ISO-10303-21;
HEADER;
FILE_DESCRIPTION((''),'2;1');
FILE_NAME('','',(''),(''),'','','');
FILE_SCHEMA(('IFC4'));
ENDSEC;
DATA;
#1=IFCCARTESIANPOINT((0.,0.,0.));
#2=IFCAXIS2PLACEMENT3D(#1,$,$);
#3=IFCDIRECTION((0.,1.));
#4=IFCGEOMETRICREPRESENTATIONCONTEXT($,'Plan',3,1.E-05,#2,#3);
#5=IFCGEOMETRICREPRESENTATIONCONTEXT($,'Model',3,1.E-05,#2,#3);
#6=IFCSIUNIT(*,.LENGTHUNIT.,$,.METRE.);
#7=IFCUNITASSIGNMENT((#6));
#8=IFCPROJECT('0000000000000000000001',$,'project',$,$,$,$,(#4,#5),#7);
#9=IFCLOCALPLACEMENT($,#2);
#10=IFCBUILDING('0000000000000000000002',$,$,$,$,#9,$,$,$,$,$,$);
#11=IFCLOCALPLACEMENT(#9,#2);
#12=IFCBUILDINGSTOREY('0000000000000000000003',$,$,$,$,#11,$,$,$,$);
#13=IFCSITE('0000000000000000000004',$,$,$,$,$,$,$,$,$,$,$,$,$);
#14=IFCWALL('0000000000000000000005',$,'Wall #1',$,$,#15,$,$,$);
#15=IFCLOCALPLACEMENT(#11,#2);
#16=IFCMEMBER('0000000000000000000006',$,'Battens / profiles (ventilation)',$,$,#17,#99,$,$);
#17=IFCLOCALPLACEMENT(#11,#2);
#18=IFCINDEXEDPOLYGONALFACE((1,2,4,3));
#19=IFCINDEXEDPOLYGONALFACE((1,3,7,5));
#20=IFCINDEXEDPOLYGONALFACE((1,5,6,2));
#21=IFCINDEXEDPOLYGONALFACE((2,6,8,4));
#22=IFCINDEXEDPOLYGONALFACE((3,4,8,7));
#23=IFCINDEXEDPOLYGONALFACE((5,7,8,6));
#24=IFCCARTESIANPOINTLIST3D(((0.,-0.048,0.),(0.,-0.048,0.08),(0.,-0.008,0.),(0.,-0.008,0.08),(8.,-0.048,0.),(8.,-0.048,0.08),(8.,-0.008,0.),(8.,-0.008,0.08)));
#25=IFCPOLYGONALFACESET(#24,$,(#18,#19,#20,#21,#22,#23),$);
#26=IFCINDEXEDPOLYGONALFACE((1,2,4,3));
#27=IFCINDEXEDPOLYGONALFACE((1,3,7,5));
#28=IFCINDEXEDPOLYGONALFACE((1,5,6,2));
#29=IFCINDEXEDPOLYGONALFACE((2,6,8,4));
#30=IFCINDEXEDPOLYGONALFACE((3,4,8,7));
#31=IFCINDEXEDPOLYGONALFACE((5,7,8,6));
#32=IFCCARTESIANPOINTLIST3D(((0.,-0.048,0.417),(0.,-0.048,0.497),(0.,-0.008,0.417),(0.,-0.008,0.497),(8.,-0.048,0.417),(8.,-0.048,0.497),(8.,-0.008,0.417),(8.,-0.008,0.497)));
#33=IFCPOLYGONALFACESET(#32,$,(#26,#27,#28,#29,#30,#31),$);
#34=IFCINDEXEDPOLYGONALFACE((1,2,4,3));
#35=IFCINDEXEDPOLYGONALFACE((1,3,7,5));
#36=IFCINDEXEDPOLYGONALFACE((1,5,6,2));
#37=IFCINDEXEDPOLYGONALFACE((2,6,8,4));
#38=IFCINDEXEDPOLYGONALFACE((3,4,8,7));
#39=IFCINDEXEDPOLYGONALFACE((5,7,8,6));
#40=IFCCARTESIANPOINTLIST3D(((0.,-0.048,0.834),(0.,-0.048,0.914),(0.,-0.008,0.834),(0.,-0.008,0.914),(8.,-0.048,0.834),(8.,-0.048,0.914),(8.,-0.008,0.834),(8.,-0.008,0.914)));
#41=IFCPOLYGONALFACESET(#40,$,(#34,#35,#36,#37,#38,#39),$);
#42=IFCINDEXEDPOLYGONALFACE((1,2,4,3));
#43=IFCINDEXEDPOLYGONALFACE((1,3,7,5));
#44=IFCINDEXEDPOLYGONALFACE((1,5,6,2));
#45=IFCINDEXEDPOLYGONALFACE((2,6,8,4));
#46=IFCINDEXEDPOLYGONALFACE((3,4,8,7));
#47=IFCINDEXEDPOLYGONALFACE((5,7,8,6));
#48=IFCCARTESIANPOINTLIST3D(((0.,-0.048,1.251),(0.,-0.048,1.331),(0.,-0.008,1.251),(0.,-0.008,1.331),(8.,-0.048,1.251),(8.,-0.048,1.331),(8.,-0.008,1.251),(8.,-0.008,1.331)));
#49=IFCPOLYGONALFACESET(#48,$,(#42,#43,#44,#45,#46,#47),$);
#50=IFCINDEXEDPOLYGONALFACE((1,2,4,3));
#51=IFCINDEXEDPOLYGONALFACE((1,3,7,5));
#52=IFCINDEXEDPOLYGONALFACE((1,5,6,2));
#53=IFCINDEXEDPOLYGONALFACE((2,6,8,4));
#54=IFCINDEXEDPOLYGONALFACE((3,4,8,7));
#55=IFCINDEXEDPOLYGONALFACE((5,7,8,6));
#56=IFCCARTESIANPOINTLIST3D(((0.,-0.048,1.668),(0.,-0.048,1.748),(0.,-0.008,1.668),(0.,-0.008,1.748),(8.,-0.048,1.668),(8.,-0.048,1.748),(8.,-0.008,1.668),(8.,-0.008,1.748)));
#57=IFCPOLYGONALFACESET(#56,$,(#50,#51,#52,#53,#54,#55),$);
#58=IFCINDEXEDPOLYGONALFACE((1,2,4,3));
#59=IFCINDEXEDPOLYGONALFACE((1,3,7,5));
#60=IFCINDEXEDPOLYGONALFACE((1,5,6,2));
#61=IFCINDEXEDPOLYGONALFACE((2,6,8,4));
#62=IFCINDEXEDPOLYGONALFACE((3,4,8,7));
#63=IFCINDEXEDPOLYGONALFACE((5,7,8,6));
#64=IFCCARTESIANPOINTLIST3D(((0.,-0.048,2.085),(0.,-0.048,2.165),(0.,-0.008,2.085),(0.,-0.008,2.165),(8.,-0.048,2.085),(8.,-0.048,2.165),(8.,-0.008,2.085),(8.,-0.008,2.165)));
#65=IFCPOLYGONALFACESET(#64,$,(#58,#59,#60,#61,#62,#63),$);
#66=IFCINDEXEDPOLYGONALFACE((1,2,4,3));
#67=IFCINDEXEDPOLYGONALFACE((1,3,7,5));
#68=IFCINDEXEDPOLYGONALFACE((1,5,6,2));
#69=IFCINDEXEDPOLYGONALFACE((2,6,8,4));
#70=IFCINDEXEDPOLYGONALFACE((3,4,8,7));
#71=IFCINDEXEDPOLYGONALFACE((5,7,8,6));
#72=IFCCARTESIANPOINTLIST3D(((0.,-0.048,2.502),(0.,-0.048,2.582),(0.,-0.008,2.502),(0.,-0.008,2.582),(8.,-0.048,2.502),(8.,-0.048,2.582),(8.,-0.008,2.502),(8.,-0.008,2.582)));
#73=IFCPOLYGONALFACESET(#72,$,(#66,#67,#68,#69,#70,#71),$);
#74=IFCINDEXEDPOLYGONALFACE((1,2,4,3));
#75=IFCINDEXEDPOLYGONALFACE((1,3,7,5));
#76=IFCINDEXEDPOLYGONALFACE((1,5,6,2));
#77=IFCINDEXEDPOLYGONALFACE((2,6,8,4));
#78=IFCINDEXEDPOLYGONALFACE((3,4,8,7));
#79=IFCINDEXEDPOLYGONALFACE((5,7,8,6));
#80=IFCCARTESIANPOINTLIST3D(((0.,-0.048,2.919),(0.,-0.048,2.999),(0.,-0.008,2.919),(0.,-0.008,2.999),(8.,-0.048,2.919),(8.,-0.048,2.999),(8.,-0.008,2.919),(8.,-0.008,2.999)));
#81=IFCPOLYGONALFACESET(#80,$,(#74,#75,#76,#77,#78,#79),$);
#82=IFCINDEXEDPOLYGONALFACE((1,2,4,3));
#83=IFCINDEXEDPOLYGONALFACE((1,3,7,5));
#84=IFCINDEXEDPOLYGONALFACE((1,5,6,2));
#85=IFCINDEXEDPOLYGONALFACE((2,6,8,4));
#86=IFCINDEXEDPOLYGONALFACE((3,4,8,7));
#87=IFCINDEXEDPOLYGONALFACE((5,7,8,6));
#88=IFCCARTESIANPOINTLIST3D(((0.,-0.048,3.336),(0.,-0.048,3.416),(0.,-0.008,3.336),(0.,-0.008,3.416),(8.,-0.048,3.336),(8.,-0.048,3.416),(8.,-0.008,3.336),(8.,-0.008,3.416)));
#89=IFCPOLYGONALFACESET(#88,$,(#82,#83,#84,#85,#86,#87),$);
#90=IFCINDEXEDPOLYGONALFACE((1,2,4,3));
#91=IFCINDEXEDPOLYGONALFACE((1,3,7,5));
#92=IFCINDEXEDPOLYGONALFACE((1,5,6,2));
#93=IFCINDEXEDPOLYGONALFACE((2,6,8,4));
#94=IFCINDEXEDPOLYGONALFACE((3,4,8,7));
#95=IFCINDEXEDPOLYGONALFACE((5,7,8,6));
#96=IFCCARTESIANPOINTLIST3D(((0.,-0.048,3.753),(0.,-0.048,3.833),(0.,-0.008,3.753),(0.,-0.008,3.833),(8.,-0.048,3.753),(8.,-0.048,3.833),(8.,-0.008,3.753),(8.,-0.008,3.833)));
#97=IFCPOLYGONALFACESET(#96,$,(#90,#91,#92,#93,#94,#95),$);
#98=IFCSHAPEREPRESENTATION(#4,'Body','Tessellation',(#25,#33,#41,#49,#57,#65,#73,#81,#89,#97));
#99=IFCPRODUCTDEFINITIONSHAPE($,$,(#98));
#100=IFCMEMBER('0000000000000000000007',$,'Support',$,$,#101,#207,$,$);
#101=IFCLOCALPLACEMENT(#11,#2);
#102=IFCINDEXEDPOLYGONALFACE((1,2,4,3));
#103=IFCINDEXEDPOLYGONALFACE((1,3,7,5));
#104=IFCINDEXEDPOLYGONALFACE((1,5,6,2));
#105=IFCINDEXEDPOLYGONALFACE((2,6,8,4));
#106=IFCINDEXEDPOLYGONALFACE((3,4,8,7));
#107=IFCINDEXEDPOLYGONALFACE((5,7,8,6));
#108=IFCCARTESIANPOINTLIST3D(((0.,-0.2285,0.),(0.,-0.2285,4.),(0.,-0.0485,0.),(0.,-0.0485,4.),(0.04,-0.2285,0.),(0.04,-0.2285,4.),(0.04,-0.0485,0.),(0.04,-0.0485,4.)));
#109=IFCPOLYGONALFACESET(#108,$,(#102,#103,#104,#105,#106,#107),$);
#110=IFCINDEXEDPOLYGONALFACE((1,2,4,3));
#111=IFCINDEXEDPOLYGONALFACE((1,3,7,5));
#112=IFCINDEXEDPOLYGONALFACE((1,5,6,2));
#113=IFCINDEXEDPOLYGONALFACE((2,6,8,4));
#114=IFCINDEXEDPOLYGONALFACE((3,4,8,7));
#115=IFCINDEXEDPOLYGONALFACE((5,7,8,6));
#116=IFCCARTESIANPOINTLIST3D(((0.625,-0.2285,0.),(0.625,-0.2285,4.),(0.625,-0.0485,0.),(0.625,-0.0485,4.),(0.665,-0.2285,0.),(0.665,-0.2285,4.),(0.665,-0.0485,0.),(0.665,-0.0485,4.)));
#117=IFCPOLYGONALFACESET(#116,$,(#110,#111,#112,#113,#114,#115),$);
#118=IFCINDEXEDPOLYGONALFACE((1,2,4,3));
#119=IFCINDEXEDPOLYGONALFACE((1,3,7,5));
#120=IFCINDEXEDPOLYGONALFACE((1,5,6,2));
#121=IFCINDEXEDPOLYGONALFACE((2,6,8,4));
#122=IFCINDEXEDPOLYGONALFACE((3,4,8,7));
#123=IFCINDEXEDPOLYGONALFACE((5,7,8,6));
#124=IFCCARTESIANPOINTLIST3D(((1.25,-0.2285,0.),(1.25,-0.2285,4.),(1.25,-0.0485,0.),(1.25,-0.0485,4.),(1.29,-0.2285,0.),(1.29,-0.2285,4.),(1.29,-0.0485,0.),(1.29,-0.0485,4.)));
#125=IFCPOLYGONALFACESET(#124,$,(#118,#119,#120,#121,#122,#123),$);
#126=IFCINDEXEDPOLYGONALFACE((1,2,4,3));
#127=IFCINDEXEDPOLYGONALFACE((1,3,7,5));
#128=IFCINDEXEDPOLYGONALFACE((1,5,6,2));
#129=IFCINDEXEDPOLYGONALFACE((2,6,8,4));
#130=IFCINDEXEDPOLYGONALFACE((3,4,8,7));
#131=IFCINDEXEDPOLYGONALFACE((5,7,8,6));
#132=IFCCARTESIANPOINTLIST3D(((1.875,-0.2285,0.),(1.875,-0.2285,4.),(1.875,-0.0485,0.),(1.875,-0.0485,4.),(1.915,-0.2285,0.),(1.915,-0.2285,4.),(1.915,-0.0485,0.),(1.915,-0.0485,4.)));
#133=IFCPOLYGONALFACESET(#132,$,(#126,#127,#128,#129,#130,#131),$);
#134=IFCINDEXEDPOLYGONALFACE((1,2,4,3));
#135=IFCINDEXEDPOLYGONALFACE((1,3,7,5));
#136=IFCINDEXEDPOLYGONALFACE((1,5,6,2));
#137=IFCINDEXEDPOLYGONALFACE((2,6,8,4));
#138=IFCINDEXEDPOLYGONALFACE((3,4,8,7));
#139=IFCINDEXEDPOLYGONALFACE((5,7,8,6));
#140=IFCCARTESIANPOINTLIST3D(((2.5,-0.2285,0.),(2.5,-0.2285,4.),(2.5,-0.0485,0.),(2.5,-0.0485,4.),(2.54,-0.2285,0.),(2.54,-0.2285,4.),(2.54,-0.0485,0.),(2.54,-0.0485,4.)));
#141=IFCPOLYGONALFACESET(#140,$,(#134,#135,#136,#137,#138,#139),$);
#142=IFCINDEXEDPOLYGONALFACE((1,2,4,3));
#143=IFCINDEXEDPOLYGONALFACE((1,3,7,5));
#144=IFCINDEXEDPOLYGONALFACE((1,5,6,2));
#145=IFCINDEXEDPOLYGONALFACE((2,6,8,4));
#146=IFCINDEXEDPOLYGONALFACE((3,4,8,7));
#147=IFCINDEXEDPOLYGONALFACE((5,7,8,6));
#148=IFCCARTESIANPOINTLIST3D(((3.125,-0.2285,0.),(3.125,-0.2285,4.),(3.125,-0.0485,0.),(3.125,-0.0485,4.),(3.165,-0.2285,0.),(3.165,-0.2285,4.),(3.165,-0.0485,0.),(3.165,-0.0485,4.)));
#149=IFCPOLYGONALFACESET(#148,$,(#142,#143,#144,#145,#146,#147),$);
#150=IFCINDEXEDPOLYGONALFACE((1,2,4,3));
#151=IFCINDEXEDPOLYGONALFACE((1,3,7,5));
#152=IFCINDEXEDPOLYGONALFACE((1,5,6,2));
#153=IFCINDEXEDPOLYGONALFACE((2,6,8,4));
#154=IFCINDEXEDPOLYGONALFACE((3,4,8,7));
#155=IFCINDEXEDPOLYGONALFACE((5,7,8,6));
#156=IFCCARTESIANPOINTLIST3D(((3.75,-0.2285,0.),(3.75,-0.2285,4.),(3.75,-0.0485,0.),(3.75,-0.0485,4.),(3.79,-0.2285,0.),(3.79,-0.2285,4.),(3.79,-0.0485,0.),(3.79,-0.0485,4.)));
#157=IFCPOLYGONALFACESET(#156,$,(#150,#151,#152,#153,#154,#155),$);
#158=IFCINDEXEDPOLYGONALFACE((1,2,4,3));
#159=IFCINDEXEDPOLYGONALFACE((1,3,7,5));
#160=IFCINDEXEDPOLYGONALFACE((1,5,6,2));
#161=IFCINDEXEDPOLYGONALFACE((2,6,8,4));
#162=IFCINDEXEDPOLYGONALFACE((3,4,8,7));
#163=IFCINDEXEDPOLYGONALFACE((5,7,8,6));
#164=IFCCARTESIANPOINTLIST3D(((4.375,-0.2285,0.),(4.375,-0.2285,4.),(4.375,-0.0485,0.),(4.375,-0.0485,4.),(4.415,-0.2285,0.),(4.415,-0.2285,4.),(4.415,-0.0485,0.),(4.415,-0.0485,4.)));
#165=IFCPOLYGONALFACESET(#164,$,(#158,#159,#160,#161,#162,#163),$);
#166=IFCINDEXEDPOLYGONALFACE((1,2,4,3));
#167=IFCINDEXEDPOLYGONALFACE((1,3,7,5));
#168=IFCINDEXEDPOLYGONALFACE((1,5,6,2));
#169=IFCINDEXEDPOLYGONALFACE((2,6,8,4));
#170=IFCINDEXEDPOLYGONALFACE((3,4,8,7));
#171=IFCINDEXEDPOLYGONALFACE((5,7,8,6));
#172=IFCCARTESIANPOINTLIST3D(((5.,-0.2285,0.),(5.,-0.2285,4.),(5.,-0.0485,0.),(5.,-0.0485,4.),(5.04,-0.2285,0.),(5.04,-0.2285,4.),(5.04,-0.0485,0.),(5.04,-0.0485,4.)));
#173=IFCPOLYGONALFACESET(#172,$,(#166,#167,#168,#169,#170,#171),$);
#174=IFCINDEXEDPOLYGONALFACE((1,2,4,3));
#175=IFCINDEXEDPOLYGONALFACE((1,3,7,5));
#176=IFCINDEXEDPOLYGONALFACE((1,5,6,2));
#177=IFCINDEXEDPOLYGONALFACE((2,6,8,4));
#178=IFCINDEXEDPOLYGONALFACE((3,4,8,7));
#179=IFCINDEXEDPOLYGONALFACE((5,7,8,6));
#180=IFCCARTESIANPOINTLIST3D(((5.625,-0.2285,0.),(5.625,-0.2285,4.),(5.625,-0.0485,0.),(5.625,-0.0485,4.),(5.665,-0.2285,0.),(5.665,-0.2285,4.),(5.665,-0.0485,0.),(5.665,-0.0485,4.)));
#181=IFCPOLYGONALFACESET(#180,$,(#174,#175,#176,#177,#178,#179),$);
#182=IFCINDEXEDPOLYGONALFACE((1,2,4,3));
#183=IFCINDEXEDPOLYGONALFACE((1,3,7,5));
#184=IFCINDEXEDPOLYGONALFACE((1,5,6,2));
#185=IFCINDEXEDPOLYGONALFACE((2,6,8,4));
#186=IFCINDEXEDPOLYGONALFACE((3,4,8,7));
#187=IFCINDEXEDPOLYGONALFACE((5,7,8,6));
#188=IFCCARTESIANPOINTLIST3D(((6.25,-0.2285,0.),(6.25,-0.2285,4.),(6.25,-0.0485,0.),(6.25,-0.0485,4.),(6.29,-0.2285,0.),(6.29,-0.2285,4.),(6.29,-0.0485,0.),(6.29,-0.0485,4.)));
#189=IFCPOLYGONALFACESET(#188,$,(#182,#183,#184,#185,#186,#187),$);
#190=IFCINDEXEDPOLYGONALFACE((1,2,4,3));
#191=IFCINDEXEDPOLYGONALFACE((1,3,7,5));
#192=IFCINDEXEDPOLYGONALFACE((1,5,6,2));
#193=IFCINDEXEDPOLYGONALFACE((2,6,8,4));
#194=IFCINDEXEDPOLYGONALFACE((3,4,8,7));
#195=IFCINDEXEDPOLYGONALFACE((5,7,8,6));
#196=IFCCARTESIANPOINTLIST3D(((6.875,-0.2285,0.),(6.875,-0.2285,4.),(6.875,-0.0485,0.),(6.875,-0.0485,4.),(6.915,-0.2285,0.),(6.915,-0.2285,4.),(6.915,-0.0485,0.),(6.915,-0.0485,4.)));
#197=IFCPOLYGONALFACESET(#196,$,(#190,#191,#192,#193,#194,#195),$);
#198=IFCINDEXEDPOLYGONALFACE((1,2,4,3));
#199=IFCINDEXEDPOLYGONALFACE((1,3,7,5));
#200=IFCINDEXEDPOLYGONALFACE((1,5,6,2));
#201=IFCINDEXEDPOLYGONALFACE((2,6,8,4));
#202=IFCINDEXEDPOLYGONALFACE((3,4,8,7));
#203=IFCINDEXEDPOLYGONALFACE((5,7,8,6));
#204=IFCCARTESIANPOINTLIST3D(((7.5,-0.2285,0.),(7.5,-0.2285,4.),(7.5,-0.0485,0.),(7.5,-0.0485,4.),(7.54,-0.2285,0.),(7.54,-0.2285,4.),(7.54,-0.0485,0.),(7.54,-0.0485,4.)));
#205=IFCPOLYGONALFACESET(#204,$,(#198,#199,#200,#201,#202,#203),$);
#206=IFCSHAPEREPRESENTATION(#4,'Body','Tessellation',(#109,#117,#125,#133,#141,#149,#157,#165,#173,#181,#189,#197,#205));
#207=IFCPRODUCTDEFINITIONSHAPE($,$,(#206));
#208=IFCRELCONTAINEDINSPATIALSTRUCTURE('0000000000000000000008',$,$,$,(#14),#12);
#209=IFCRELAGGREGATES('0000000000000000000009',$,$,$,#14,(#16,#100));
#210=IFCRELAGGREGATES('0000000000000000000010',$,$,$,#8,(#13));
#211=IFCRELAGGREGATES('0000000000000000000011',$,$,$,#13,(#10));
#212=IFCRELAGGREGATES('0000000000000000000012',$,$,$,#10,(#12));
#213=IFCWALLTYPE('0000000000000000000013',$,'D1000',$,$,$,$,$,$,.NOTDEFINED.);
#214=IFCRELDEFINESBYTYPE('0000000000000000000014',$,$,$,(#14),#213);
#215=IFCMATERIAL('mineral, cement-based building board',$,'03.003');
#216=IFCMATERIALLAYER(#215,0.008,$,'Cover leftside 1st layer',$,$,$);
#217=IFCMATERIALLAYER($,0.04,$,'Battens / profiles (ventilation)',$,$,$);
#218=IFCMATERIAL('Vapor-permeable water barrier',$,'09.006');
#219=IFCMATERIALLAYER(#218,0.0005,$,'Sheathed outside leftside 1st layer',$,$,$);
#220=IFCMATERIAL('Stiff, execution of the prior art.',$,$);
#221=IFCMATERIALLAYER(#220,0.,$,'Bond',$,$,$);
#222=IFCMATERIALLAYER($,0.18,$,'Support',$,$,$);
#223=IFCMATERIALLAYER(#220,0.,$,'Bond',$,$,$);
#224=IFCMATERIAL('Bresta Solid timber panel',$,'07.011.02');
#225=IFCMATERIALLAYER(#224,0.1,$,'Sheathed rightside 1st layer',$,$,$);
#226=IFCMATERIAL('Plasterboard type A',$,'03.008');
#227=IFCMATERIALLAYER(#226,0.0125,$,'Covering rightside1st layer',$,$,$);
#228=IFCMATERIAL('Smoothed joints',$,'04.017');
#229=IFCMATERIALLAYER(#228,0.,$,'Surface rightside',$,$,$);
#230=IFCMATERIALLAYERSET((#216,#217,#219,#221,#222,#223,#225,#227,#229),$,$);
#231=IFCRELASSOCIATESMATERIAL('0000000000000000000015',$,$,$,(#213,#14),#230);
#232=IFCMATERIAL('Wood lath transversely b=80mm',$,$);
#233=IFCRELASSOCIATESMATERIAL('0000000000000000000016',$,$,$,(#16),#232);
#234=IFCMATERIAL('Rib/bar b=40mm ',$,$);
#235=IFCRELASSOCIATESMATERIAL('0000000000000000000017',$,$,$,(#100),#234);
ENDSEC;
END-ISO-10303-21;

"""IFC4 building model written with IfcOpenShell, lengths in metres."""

from ifc_helpers import new_model, si_unit, direction, frame, frame_2d, origin, place, context, project, spatial, rectangle, extrude, material, layer, layer_set, type_object, element, aggregate, save


model = new_model("IFC4")

# Units and contexts
plan_context = context("Plan", 3, precision=1e-05, world=origin(), true_north=direction((0.0, 1.0)))
model_context = context("Model", 3, precision=1e-05, world=origin(), true_north=direction((0.0, 1.0)))
ifc_project = project(units=[si_unit("LENGTHUNIT", "METRE")], contexts=[plan_context, model_context])

# Site, building, storey
site = spatial("IfcSite", under=ifc_project)
building_placement = place(None, origin())
building = spatial("IfcBuilding", under=site, at=building_placement)
storey_placement = place(building_placement, origin())
storey = spatial("IfcBuildingStorey", under=building, at=storey_placement)

# Wall, members
ifc_material_1 = material(Name="mineral, cement-based building board", Category="03.003")
ifc_layer_1 = layer(ifc_material_1, 0.008, Name="Cover leftside 1st layer")
ifc_layer_2 = layer(None, 0.04, Name="Battens / profiles (ventilation)")
ifc_material_2 = material(Name="Vapor-permeable water barrier", Category="09.006")
ifc_layer_3 = layer(ifc_material_2, 0.0005, Name="Sheathed outside leftside 1st layer")
ifc_material_3 = material(Name="Stiff, execution of the prior art.")
ifc_layer_4 = layer(ifc_material_3, 0.0, Name="Bond")
ifc_layer_5 = layer(None, 0.18, Name="Support")
ifc_layer_6 = layer(ifc_material_3, 0.0, Name="Bond")
ifc_material_4 = material(Name="Bresta Solid timber panel", Category="07.011.02")
ifc_layer_7 = layer(ifc_material_4, 0.1, Name="Sheathed rightside 1st layer")
ifc_material_5 = material(Name="Plasterboard type A", Category="03.008")
ifc_layer_8 = layer(ifc_material_5, 0.0125, Name="Covering rightside1st layer")
ifc_material_6 = material(Name="Smoothed joints", Category="04.017")
ifc_layer_9 = layer(ifc_material_6, 0.0, Name="Surface rightside")
ifc_layer_set = layer_set([ifc_layer_1, ifc_layer_2, ifc_layer_3, ifc_layer_4, ifc_layer_5, ifc_layer_6, ifc_layer_7, ifc_layer_8, ifc_layer_9])
wall_type = type_object("IfcWallType", Name="D1000", PredefinedType="NOTDEFINED", material=ifc_layer_set)
wall_placement = place(None, frame((0.0, 0.0, 0.0), z_axis=(0.0, -1.0, 0.0), x_axis=(1.0, 0.0, 0.0)))
wall = element("IfcWall", 1, at=wall_placement, inside=storey, type_object=wall_type, material=ifc_layer_set, Name="Wall #1")
ifc_material_7 = material(Name="Wood lath transversely b=80mm")
member_1_placement = place(wall_placement, origin())
member_1 = element("IfcMember", 2, at=member_1_placement, material=ifc_material_7, Name="Battens / profiles (ventilation)", context=plan_context, shape_type="SweptSolid", body=[
    extrude(rectangle(XDim=0.08, YDim=0.04, at=frame_2d((0.04, 0.02), x_axis=(1.0, 0.0))), frame((0.0, 0.0, 0.008), z_axis=(1.0, 0.0, 0.0), x_axis=(0.0, 1.0, 0.0)), (0.0, 0.0, 1.0), 8.0),
    extrude(rectangle(XDim=0.08, YDim=0.04, at=frame_2d((0.04, 0.02), x_axis=(1.0, 0.0))), frame((0.0, 0.417, 0.008), z_axis=(1.0, 0.0, 0.0), x_axis=(0.0, 1.0, 0.0)), (0.0, 0.0, 1.0), 8.0),
    extrude(rectangle(XDim=0.08, YDim=0.04, at=frame_2d((0.04, 0.02), x_axis=(1.0, 0.0))), frame((0.0, 0.834, 0.008), z_axis=(1.0, 0.0, 0.0), x_axis=(0.0, 1.0, 0.0)), (0.0, 0.0, 1.0), 8.0),
    extrude(rectangle(XDim=0.08, YDim=0.04, at=frame_2d((0.04, 0.02), x_axis=(1.0, 0.0))), frame((0.0, 1.251, 0.008), z_axis=(1.0, 0.0, 0.0), x_axis=(0.0, 1.0, 0.0)), (0.0, 0.0, 1.0), 8.0),
    extrude(rectangle(XDim=0.08, YDim=0.04, at=frame_2d((0.04, 0.02), x_axis=(1.0, 0.0))), frame((0.0, 1.668, 0.008), z_axis=(1.0, 0.0, 0.0), x_axis=(0.0, 1.0, 0.0)), (0.0, 0.0, 1.0), 8.0),
    extrude(rectangle(XDim=0.08, YDim=0.04, at=frame_2d((0.04, 0.02), x_axis=(1.0, 0.0))), frame((0.0, 2.085, 0.008), z_axis=(1.0, 0.0, 0.0), x_axis=(0.0, 1.0, 0.0)), (0.0, 0.0, 1.0), 8.0),
    extrude(rectangle(XDim=0.08, YDim=0.04, at=frame_2d((0.04, 0.02), x_axis=(1.0, 0.0))), frame((0.0, 2.502, 0.008), z_axis=(1.0, 0.0, 0.0), x_axis=(0.0, 1.0, 0.0)), (0.0, 0.0, 1.0), 8.0),
    extrude(rectangle(XDim=0.08, YDim=0.04, at=frame_2d((0.04, 0.02), x_axis=(1.0, 0.0))), frame((0.0, 2.919, 0.008), z_axis=(1.0, 0.0, 0.0), x_axis=(0.0, 1.0, 0.0)), (0.0, 0.0, 1.0), 8.0),
    extrude(rectangle(XDim=0.08, YDim=0.04, at=frame_2d((0.04, 0.02), x_axis=(1.0, 0.0))), frame((0.0, 3.336, 0.008), z_axis=(1.0, 0.0, 0.0), x_axis=(0.0, 1.0, 0.0)), (0.0, 0.0, 1.0), 8.0),
    extrude(rectangle(XDim=0.08, YDim=0.04, at=frame_2d((0.04, 0.02), x_axis=(1.0, 0.0))), frame((0.0, 3.753, 0.008), z_axis=(1.0, 0.0, 0.0), x_axis=(0.0, 1.0, 0.0)), (0.0, 0.0, 1.0), 8.0),
])
ifc_material_8 = material(Name="Rib/bar b=40mm ")
member_2_placement = place(wall_placement, origin())
member_2 = element("IfcMember", 3, at=member_2_placement, material=ifc_material_8, Name="Support", context=plan_context, shape_type="SweptSolid", body=[
    extrude(rectangle(XDim=0.04, YDim=0.18, at=frame_2d((0.02, 0.09), x_axis=(1.0, 0.0))), frame((0.0, 4.0, 0.0485), z_axis=(0.0, -1.0, 0.0), x_axis=(1.0, 0.0, 0.0)), (0.0, 0.0, 1.0), 4.0),
    extrude(rectangle(XDim=0.04, YDim=0.18, at=frame_2d((0.02, 0.09), x_axis=(1.0, 0.0))), frame((0.625, 4.0, 0.0485), z_axis=(0.0, -1.0, 0.0), x_axis=(1.0, 0.0, 0.0)), (0.0, 0.0, 1.0), 4.0),
    extrude(rectangle(XDim=0.04, YDim=0.18, at=frame_2d((0.02, 0.09), x_axis=(1.0, 0.0))), frame((1.25, 4.0, 0.0485), z_axis=(0.0, -1.0, 0.0), x_axis=(1.0, 0.0, 0.0)), (0.0, 0.0, 1.0), 4.0),
    extrude(rectangle(XDim=0.04, YDim=0.18, at=frame_2d((0.02, 0.09), x_axis=(1.0, 0.0))), frame((1.875, 4.0, 0.0485), z_axis=(0.0, -1.0, 0.0), x_axis=(1.0, 0.0, 0.0)), (0.0, 0.0, 1.0), 4.0),
    extrude(rectangle(XDim=0.04, YDim=0.18, at=frame_2d((0.02, 0.09), x_axis=(1.0, 0.0))), frame((2.5, 4.0, 0.0485), z_axis=(0.0, -1.0, 0.0), x_axis=(1.0, 0.0, 0.0)), (0.0, 0.0, 1.0), 4.0),
    extrude(rectangle(XDim=0.04, YDim=0.18, at=frame_2d((0.02, 0.09), x_axis=(1.0, 0.0))), frame((3.125, 4.0, 0.0485), z_axis=(0.0, -1.0, 0.0), x_axis=(1.0, 0.0, 0.0)), (0.0, 0.0, 1.0), 4.0),
    extrude(rectangle(XDim=0.04, YDim=0.18, at=frame_2d((0.02, 0.09), x_axis=(1.0, 0.0))), frame((3.75, 4.0, 0.0485), z_axis=(0.0, -1.0, 0.0), x_axis=(1.0, 0.0, 0.0)), (0.0, 0.0, 1.0), 4.0),
    extrude(rectangle(XDim=0.04, YDim=0.18, at=frame_2d((0.02, 0.09), x_axis=(1.0, 0.0))), frame((4.375, 4.0, 0.0485), z_axis=(0.0, -1.0, 0.0), x_axis=(1.0, 0.0, 0.0)), (0.0, 0.0, 1.0), 4.0),
    extrude(rectangle(XDim=0.04, YDim=0.18, at=frame_2d((0.02, 0.09), x_axis=(1.0, 0.0))), frame((5.0, 4.0, 0.0485), z_axis=(0.0, -1.0, 0.0), x_axis=(1.0, 0.0, 0.0)), (0.0, 0.0, 1.0), 4.0),
    extrude(rectangle(XDim=0.04, YDim=0.18, at=frame_2d((0.02, 0.09), x_axis=(1.0, 0.0))), frame((5.625, 4.0, 0.0485), z_axis=(0.0, -1.0, 0.0), x_axis=(1.0, 0.0, 0.0)), (0.0, 0.0, 1.0), 4.0),
    extrude(rectangle(XDim=0.04, YDim=0.18, at=frame_2d((0.02, 0.09), x_axis=(1.0, 0.0))), frame((6.25, 4.0, 0.0485), z_axis=(0.0, -1.0, 0.0), x_axis=(1.0, 0.0, 0.0)), (0.0, 0.0, 1.0), 4.0),
    extrude(rectangle(XDim=0.04, YDim=0.18, at=frame_2d((0.02, 0.09), x_axis=(1.0, 0.0))), frame((6.875, 4.0, 0.0485), z_axis=(0.0, -1.0, 0.0), x_axis=(1.0, 0.0, 0.0)), (0.0, 0.0, 1.0), 4.0),
    extrude(rectangle(XDim=0.04, YDim=0.18, at=frame_2d((0.02, 0.09), x_axis=(1.0, 0.0))), frame((7.5, 4.0, 0.0485), z_axis=(0.0, -1.0, 0.0), x_axis=(1.0, 0.0, 0.0)), (0.0, 0.0, 1.0), 4.0),
])
aggregate(wall, [member_1, member_2])

save(model, "model.ifc")
